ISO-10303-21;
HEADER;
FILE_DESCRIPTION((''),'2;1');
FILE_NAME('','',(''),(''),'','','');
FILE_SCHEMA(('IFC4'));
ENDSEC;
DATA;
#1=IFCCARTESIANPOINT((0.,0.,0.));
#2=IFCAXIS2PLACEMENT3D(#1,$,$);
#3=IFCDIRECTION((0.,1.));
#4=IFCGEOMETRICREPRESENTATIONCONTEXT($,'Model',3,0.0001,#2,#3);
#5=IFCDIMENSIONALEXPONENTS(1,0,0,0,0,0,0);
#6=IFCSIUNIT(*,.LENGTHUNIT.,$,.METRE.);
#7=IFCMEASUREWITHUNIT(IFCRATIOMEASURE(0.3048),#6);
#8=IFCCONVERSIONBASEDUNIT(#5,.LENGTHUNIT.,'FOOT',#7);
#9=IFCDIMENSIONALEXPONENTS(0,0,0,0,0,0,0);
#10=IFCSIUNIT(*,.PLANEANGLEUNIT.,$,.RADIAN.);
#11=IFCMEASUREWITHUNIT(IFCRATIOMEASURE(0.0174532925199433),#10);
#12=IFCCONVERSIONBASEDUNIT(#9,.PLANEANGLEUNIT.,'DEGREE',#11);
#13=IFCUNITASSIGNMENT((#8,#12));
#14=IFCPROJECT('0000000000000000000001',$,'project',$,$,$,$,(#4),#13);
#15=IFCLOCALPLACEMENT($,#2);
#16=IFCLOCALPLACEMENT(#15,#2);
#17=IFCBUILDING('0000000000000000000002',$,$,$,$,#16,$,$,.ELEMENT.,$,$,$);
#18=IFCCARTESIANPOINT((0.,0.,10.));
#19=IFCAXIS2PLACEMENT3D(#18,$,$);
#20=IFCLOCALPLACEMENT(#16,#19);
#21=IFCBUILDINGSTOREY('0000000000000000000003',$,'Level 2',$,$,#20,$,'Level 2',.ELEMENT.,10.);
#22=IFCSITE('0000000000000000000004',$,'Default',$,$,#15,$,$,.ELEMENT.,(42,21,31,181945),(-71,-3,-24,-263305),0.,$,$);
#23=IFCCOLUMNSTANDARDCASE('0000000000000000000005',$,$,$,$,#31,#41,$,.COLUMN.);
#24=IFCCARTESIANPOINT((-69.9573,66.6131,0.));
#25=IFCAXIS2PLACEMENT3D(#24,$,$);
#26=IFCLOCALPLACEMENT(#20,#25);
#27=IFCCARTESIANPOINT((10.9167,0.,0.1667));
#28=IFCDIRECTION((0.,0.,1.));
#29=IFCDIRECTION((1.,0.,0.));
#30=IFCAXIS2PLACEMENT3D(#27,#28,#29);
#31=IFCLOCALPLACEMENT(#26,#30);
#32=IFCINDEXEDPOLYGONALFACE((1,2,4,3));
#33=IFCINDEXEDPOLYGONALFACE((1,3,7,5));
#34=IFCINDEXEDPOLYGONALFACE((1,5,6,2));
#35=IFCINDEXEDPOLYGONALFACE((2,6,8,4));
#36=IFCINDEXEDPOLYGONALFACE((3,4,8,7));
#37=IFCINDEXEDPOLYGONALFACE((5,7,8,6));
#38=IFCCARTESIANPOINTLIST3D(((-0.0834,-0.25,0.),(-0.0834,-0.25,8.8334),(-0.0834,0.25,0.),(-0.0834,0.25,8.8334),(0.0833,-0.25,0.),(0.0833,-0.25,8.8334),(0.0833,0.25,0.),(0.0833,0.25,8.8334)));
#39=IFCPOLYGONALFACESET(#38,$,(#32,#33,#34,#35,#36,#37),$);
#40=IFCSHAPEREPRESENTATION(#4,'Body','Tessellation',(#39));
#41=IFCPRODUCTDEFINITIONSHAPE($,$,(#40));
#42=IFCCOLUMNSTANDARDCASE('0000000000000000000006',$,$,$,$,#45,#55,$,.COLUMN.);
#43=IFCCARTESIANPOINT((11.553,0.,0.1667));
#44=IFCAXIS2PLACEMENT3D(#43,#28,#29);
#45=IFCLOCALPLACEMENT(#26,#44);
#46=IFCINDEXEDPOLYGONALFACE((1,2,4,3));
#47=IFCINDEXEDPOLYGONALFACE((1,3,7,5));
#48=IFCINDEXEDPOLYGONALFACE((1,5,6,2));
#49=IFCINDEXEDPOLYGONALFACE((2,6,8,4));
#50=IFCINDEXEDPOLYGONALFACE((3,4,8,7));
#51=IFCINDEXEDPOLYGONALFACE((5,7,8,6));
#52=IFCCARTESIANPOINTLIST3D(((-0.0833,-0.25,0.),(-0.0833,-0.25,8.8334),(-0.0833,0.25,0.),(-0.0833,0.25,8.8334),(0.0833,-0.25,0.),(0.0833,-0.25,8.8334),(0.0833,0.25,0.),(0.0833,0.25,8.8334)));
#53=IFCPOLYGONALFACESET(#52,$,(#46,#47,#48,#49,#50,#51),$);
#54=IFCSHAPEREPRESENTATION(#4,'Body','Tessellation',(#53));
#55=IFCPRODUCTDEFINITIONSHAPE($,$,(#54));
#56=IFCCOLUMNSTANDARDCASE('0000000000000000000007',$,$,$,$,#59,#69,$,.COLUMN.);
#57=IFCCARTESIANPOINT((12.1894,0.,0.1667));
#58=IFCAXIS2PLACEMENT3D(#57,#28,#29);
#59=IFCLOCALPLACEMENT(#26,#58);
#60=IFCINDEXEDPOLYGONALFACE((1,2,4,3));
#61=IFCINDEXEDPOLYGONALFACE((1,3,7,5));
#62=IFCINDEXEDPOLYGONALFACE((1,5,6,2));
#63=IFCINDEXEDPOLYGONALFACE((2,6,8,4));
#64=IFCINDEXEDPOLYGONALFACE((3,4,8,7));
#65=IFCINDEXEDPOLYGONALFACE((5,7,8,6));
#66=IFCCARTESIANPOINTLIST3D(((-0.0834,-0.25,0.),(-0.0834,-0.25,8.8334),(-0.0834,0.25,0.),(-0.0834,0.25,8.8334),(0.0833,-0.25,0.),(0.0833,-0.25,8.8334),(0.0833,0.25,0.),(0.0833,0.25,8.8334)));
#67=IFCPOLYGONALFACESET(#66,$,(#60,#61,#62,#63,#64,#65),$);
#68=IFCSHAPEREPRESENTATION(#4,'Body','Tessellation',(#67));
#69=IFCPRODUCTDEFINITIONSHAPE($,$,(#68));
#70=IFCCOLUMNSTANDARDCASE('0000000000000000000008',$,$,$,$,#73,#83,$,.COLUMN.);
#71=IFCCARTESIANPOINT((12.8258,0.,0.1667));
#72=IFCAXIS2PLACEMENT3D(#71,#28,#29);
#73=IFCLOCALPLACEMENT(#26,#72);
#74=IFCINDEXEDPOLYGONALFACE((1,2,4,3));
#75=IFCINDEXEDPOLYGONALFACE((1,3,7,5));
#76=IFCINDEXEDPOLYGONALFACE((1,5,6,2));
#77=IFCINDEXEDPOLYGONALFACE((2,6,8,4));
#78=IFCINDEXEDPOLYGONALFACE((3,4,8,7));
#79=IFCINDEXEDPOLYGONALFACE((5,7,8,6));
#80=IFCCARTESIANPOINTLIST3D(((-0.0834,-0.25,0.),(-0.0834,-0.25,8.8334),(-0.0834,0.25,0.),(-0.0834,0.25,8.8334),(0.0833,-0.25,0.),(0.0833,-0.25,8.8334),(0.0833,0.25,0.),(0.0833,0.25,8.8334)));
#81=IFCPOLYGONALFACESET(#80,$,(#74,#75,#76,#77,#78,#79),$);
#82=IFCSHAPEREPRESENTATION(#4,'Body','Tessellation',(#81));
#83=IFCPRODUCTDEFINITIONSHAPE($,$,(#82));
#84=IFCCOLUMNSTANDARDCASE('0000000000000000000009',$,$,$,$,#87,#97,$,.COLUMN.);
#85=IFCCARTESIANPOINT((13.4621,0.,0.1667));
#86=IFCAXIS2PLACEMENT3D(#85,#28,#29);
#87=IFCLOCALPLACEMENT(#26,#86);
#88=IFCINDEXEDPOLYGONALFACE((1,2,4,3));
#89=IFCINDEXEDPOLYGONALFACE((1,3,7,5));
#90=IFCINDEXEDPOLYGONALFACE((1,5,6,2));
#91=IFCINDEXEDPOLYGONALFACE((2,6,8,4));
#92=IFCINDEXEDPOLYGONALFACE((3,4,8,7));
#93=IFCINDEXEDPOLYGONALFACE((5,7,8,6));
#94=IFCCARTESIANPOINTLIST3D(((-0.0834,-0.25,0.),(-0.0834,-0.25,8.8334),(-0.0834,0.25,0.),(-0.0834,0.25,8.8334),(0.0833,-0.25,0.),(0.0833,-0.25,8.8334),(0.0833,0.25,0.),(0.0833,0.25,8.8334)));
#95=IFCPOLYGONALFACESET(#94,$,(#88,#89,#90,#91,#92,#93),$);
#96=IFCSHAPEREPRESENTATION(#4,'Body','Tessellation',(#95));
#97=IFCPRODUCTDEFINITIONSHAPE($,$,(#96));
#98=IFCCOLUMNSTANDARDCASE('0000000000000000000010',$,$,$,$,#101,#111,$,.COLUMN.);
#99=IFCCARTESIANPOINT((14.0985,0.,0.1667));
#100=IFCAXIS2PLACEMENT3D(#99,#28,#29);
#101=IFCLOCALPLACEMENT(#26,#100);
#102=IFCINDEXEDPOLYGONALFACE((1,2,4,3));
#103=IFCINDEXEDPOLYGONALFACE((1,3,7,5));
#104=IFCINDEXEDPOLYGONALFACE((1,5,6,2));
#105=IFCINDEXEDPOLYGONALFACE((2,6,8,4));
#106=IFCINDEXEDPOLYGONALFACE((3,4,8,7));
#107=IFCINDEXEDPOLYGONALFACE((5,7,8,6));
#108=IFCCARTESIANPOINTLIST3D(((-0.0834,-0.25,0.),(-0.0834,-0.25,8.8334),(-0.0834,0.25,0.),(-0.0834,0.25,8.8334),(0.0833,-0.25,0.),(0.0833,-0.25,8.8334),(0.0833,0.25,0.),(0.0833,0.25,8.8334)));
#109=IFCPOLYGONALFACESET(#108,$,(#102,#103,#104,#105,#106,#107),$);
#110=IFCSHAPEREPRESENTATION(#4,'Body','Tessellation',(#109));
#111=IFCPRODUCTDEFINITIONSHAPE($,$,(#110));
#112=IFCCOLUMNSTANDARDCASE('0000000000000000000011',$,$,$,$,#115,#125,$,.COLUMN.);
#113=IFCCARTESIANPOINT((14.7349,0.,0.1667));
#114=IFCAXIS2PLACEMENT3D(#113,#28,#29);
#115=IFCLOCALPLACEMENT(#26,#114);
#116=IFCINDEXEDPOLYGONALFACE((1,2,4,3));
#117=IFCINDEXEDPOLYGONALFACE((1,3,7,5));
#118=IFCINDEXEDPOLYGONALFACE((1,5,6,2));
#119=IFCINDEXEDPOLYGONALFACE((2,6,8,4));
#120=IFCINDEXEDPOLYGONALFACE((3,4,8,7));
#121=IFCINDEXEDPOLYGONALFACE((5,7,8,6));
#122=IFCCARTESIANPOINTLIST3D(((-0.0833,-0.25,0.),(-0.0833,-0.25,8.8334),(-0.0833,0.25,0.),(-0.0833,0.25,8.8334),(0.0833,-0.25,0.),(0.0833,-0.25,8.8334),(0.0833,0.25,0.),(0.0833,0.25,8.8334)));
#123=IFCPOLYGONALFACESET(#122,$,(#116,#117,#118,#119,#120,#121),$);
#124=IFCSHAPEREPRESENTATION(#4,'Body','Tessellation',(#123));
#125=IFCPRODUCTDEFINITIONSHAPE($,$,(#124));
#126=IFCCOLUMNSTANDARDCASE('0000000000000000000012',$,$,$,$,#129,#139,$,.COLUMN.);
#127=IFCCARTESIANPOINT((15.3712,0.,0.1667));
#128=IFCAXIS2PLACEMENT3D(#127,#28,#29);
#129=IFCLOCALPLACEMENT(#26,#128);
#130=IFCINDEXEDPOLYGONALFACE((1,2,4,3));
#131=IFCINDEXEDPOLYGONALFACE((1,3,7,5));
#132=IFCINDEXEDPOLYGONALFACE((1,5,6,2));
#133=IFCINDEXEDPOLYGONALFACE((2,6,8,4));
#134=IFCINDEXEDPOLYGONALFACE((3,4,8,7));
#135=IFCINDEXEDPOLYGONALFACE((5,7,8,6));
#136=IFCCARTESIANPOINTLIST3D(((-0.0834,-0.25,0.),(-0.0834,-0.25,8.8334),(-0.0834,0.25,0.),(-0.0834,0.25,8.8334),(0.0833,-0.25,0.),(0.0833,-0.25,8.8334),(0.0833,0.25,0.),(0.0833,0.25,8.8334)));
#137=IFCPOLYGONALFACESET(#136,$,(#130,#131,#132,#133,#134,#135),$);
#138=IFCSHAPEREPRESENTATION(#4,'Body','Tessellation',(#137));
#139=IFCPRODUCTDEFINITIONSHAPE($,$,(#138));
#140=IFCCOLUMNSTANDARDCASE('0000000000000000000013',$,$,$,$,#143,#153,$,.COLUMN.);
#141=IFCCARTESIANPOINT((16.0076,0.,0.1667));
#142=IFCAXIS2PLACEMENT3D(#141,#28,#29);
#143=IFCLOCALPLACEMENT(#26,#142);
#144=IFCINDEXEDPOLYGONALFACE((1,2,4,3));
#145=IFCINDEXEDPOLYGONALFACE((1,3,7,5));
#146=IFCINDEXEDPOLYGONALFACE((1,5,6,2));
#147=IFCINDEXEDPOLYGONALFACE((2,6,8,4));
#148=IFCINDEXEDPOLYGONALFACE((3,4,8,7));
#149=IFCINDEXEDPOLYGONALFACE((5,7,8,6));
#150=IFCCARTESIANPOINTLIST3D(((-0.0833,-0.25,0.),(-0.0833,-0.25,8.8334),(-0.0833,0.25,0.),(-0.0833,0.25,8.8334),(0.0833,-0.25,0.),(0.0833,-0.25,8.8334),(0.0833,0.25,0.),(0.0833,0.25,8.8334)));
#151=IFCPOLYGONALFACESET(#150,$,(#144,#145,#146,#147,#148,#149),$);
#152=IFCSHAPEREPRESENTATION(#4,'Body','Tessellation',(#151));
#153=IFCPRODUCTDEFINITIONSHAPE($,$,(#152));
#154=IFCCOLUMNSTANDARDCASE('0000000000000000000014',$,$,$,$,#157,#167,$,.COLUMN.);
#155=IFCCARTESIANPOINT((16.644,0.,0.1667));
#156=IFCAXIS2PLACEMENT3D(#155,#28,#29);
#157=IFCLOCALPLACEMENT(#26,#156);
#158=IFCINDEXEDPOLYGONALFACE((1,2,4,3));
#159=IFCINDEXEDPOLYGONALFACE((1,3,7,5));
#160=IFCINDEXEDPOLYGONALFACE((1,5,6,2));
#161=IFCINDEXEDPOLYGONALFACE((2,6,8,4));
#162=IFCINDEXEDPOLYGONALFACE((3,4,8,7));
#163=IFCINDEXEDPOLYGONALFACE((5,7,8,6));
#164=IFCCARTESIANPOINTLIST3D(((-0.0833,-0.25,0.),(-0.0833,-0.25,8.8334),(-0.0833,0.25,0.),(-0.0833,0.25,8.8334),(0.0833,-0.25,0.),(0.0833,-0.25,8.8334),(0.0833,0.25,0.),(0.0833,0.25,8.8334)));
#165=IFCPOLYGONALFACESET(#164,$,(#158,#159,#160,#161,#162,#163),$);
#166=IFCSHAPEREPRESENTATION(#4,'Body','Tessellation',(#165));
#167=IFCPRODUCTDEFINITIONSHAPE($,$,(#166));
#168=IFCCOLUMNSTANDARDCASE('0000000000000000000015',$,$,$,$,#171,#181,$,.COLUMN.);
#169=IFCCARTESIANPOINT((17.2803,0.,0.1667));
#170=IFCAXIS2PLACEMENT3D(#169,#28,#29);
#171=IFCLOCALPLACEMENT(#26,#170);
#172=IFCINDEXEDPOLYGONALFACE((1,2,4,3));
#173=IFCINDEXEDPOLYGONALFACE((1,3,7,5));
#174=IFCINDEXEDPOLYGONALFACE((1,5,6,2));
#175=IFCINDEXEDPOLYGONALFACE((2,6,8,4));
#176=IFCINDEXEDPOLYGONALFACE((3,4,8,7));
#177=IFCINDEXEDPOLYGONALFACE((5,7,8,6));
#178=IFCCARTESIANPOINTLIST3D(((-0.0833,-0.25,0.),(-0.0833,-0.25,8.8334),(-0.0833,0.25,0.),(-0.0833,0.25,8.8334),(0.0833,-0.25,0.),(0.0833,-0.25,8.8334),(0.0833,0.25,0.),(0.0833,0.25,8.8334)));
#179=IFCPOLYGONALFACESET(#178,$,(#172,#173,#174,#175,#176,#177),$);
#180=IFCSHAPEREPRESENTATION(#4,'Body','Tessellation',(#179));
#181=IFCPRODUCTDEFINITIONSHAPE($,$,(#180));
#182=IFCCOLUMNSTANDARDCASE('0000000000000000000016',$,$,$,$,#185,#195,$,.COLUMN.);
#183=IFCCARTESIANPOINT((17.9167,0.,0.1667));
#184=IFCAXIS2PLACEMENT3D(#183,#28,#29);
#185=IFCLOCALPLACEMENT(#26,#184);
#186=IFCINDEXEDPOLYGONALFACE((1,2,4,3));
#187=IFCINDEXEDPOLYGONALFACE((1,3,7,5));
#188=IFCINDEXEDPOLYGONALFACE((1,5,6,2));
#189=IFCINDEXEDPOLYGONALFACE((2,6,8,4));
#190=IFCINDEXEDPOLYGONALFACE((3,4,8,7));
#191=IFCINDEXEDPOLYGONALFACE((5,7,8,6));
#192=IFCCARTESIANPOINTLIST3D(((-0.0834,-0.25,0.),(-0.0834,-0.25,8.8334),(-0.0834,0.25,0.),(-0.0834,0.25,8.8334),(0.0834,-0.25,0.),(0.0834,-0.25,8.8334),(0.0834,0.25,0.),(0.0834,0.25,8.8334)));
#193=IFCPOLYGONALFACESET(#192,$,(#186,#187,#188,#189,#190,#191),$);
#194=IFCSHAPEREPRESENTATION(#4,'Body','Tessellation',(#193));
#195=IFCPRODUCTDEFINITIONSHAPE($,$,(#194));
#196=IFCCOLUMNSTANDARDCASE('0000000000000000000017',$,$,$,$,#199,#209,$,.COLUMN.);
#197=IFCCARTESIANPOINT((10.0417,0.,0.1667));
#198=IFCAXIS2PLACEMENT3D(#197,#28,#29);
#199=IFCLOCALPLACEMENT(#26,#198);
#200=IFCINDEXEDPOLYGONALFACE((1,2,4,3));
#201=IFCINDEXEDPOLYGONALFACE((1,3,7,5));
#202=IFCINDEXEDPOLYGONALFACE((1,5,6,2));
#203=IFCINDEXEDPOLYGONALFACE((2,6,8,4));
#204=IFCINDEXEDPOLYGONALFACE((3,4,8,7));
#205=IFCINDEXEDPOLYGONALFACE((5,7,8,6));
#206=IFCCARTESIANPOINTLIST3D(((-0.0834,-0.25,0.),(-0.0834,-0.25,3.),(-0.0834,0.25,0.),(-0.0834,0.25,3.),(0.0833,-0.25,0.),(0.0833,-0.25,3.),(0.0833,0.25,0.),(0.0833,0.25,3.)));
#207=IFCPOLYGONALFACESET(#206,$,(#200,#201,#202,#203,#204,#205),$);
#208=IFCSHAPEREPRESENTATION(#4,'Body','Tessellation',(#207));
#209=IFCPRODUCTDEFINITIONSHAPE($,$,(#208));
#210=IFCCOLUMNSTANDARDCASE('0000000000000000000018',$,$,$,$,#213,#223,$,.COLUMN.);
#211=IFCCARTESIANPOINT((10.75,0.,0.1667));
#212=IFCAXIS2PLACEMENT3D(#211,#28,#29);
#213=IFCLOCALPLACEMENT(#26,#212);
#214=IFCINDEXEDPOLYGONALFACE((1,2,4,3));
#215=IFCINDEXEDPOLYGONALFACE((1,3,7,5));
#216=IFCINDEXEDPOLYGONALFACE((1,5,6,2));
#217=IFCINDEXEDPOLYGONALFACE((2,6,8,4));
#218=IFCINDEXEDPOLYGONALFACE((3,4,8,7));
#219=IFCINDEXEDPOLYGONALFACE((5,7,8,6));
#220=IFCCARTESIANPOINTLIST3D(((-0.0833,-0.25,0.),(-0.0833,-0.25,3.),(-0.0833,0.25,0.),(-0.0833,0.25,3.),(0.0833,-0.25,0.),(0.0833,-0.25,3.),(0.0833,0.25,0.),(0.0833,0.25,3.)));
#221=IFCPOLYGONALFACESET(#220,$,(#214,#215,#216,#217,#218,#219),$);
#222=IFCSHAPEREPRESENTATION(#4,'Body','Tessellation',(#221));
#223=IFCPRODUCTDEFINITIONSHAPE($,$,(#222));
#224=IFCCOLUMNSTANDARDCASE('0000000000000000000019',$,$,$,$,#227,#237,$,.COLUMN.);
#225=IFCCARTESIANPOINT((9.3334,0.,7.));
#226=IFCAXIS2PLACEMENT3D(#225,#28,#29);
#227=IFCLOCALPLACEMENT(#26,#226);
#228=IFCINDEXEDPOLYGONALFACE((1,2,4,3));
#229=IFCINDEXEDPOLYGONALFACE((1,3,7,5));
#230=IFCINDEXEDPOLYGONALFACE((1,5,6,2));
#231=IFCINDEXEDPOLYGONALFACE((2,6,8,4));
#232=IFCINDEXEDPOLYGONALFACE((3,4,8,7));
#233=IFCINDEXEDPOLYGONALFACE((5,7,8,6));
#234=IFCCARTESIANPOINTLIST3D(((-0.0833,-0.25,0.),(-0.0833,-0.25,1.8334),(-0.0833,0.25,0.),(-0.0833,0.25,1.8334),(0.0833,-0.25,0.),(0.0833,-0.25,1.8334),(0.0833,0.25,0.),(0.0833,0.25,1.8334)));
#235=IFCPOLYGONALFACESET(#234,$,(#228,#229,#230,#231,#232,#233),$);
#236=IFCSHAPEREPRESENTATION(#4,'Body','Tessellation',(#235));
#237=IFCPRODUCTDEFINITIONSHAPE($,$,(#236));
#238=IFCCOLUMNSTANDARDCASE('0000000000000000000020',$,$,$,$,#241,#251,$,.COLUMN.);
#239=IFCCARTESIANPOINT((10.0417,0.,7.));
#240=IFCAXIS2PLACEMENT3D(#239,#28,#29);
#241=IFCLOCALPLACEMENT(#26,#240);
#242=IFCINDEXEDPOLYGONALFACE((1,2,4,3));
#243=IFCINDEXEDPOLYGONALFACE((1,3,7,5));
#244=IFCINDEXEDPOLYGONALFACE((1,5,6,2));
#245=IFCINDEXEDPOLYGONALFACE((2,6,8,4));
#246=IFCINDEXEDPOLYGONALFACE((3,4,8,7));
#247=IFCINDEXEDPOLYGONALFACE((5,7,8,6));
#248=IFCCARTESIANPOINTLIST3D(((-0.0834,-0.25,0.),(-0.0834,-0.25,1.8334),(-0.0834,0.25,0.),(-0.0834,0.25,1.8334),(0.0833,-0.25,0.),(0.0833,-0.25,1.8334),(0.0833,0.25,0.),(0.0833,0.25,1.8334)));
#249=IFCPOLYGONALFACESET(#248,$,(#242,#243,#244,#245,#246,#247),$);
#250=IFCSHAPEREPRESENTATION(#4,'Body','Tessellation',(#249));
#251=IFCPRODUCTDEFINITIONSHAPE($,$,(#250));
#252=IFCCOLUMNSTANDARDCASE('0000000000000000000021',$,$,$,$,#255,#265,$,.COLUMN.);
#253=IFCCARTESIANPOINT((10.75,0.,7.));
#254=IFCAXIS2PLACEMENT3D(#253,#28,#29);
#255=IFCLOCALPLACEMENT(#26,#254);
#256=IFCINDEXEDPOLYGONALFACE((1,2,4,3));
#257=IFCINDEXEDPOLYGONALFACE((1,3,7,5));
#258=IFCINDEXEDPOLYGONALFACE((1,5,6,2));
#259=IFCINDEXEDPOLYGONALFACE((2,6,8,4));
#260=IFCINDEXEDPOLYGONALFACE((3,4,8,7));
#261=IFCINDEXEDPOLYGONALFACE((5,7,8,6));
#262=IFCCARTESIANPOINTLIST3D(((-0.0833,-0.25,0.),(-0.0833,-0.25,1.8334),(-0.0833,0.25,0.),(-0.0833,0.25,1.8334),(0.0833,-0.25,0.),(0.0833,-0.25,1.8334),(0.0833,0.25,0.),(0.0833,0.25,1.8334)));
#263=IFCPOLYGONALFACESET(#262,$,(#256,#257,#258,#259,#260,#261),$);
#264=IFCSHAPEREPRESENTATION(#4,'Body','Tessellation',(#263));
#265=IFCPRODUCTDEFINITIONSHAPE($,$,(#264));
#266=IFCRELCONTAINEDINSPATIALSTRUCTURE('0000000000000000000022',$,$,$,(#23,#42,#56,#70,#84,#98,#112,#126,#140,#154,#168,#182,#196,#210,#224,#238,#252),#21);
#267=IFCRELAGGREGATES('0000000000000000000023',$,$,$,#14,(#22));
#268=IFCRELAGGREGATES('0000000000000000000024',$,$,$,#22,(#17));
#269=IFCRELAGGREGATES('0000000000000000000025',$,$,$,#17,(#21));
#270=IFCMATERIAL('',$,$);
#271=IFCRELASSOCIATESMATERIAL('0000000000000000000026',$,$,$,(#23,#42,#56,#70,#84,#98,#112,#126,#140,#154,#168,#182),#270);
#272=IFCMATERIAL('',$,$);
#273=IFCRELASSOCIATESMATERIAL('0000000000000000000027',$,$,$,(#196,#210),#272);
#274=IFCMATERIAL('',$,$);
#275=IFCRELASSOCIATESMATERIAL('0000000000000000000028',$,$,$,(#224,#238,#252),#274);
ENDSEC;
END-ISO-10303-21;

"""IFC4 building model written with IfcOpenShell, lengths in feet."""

from ifc_helpers import new_model, entity, si_unit, converted_unit, direction, frame, origin, place, context, project, spatial, rectangle, extrude, material, element, save


model = new_model("IFC4")

# Units and contexts
model_context = context("Model", 3, precision=0.0001, world=origin(), true_north=direction((0.0, 1.0)))
ifc_project = project(units=[converted_unit("LENGTHUNIT", "FOOT", entity("IfcRatioMeasure", 0.3048), si_unit("LENGTHUNIT", "METRE"), dimensions=[1, 0, 0, 0, 0, 0, 0]), converted_unit("PLANEANGLEUNIT", "DEGREE", entity("IfcRatioMeasure", 0.0174532925199433), si_unit("PLANEANGLEUNIT", "RADIAN"), dimensions=[0, 0, 0, 0, 0, 0, 0])], contexts=[model_context])

# Site, building, storey
site_placement = place(None, origin())
site = spatial("IfcSite", under=ifc_project, at=site_placement, Name="Default", CompositionType="ELEMENT", RefLatitude=(42, 21, 31, 181945), RefLongitude=(-71, -3, -24, -263305), RefElevation=0.0)
building_placement = place(site_placement, origin())
building = spatial("IfcBuilding", under=site, at=building_placement, CompositionType="ELEMENT")
storey_placement = place(building_placement, frame((0.0, 0.0, 10.0)))
storey = spatial("IfcBuildingStorey", under=building, at=storey_placement, Name="Level 2", LongName="Level 2", CompositionType="ELEMENT", Elevation=10.0)

# Columns
ifc_material_1 = material(Name="")
placement_1 = place(storey_placement, frame((-69.9573, 66.6131, 0.0)))
for number, where, z_axis, x_axis in (
    (1, (10.9167, 0.0, 0.1667), (0.0, 0.0, 1.0), (1.0, 0.0, 0.0)),
    (2, (11.553, 0.0, 0.1667), (0.0, 0.0, 1.0), (1.0, 0.0, 0.0)),
    (3, (12.1894, 0.0, 0.1667), (0.0, 0.0, 1.0), (1.0, 0.0, 0.0)),
    (4, (12.8258, 0.0, 0.1667), (0.0, 0.0, 1.0), (1.0, 0.0, 0.0)),
    (5, (13.4621, 0.0, 0.1667), (0.0, 0.0, 1.0), (1.0, 0.0, 0.0)),
    (6, (14.0985, 0.0, 0.1667), (0.0, 0.0, 1.0), (1.0, 0.0, 0.0)),
    (7, (14.7349, 0.0, 0.1667), (0.0, 0.0, 1.0), (1.0, 0.0, 0.0)),
    (8, (15.3712, 0.0, 0.1667), (0.0, 0.0, 1.0), (1.0, 0.0, 0.0)),
    (9, (16.0076, 0.0, 0.1667), (0.0, 0.0, 1.0), (1.0, 0.0, 0.0)),
    (10, (16.644, 0.0, 0.1667), (0.0, 0.0, 1.0), (1.0, 0.0, 0.0)),
    (11, (17.2803, 0.0, 0.1667), (0.0, 0.0, 1.0), (1.0, 0.0, 0.0)),
    (12, (17.9167, 0.0, 0.1667), (0.0, 0.0, 1.0), (1.0, 0.0, 0.0)),
):
    element("IfcColumnStandardCase", number, at=place(placement_1, frame(where, z_axis=z_axis, x_axis=x_axis)), inside=storey, material=ifc_material_1, PredefinedType="COLUMN", context=model_context, shape_type="SweptSolid", body=[
        extrude(rectangle(XDim=0.1667, YDim=0.5), origin(), (0.0, 0.0, 1.0), 8.8334),
    ])
ifc_material_2 = material(Name="")
for number, where, z_axis, x_axis in (
    (13, (10.0417, 0.0, 0.1667), (0.0, 0.0, 1.0), (1.0, 0.0, 0.0)),
    (14, (10.75, 0.0, 0.1667), (0.0, 0.0, 1.0), (1.0, 0.0, 0.0)),
):
    element("IfcColumnStandardCase", number, at=place(placement_1, frame(where, z_axis=z_axis, x_axis=x_axis)), inside=storey, material=ifc_material_2, PredefinedType="COLUMN", context=model_context, shape_type="SweptSolid", body=[
        extrude(rectangle(XDim=0.1667, YDim=0.5), origin(), (0.0, 0.0, 1.0), 3.0),
    ])
ifc_material_3 = material(Name="")
for number, where, z_axis, x_axis in (
    (15, (9.3334, 0.0, 7.0), (0.0, 0.0, 1.0), (1.0, 0.0, 0.0)),
    (16, (10.0417, 0.0, 7.0), (0.0, 0.0, 1.0), (1.0, 0.0, 0.0)),
    (17, (10.75, 0.0, 7.0), (0.0, 0.0, 1.0), (1.0, 0.0, 0.0)),
):
    element("IfcColumnStandardCase", number, at=place(placement_1, frame(where, z_axis=z_axis, x_axis=x_axis)), inside=storey, material=ifc_material_3, PredefinedType="COLUMN", context=model_context, shape_type="SweptSolid", body=[
        extrude(rectangle(XDim=0.1667, YDim=0.5), origin(), (0.0, 0.0, 1.0), 1.8334),
    ])

save(model, "model.ifc")
